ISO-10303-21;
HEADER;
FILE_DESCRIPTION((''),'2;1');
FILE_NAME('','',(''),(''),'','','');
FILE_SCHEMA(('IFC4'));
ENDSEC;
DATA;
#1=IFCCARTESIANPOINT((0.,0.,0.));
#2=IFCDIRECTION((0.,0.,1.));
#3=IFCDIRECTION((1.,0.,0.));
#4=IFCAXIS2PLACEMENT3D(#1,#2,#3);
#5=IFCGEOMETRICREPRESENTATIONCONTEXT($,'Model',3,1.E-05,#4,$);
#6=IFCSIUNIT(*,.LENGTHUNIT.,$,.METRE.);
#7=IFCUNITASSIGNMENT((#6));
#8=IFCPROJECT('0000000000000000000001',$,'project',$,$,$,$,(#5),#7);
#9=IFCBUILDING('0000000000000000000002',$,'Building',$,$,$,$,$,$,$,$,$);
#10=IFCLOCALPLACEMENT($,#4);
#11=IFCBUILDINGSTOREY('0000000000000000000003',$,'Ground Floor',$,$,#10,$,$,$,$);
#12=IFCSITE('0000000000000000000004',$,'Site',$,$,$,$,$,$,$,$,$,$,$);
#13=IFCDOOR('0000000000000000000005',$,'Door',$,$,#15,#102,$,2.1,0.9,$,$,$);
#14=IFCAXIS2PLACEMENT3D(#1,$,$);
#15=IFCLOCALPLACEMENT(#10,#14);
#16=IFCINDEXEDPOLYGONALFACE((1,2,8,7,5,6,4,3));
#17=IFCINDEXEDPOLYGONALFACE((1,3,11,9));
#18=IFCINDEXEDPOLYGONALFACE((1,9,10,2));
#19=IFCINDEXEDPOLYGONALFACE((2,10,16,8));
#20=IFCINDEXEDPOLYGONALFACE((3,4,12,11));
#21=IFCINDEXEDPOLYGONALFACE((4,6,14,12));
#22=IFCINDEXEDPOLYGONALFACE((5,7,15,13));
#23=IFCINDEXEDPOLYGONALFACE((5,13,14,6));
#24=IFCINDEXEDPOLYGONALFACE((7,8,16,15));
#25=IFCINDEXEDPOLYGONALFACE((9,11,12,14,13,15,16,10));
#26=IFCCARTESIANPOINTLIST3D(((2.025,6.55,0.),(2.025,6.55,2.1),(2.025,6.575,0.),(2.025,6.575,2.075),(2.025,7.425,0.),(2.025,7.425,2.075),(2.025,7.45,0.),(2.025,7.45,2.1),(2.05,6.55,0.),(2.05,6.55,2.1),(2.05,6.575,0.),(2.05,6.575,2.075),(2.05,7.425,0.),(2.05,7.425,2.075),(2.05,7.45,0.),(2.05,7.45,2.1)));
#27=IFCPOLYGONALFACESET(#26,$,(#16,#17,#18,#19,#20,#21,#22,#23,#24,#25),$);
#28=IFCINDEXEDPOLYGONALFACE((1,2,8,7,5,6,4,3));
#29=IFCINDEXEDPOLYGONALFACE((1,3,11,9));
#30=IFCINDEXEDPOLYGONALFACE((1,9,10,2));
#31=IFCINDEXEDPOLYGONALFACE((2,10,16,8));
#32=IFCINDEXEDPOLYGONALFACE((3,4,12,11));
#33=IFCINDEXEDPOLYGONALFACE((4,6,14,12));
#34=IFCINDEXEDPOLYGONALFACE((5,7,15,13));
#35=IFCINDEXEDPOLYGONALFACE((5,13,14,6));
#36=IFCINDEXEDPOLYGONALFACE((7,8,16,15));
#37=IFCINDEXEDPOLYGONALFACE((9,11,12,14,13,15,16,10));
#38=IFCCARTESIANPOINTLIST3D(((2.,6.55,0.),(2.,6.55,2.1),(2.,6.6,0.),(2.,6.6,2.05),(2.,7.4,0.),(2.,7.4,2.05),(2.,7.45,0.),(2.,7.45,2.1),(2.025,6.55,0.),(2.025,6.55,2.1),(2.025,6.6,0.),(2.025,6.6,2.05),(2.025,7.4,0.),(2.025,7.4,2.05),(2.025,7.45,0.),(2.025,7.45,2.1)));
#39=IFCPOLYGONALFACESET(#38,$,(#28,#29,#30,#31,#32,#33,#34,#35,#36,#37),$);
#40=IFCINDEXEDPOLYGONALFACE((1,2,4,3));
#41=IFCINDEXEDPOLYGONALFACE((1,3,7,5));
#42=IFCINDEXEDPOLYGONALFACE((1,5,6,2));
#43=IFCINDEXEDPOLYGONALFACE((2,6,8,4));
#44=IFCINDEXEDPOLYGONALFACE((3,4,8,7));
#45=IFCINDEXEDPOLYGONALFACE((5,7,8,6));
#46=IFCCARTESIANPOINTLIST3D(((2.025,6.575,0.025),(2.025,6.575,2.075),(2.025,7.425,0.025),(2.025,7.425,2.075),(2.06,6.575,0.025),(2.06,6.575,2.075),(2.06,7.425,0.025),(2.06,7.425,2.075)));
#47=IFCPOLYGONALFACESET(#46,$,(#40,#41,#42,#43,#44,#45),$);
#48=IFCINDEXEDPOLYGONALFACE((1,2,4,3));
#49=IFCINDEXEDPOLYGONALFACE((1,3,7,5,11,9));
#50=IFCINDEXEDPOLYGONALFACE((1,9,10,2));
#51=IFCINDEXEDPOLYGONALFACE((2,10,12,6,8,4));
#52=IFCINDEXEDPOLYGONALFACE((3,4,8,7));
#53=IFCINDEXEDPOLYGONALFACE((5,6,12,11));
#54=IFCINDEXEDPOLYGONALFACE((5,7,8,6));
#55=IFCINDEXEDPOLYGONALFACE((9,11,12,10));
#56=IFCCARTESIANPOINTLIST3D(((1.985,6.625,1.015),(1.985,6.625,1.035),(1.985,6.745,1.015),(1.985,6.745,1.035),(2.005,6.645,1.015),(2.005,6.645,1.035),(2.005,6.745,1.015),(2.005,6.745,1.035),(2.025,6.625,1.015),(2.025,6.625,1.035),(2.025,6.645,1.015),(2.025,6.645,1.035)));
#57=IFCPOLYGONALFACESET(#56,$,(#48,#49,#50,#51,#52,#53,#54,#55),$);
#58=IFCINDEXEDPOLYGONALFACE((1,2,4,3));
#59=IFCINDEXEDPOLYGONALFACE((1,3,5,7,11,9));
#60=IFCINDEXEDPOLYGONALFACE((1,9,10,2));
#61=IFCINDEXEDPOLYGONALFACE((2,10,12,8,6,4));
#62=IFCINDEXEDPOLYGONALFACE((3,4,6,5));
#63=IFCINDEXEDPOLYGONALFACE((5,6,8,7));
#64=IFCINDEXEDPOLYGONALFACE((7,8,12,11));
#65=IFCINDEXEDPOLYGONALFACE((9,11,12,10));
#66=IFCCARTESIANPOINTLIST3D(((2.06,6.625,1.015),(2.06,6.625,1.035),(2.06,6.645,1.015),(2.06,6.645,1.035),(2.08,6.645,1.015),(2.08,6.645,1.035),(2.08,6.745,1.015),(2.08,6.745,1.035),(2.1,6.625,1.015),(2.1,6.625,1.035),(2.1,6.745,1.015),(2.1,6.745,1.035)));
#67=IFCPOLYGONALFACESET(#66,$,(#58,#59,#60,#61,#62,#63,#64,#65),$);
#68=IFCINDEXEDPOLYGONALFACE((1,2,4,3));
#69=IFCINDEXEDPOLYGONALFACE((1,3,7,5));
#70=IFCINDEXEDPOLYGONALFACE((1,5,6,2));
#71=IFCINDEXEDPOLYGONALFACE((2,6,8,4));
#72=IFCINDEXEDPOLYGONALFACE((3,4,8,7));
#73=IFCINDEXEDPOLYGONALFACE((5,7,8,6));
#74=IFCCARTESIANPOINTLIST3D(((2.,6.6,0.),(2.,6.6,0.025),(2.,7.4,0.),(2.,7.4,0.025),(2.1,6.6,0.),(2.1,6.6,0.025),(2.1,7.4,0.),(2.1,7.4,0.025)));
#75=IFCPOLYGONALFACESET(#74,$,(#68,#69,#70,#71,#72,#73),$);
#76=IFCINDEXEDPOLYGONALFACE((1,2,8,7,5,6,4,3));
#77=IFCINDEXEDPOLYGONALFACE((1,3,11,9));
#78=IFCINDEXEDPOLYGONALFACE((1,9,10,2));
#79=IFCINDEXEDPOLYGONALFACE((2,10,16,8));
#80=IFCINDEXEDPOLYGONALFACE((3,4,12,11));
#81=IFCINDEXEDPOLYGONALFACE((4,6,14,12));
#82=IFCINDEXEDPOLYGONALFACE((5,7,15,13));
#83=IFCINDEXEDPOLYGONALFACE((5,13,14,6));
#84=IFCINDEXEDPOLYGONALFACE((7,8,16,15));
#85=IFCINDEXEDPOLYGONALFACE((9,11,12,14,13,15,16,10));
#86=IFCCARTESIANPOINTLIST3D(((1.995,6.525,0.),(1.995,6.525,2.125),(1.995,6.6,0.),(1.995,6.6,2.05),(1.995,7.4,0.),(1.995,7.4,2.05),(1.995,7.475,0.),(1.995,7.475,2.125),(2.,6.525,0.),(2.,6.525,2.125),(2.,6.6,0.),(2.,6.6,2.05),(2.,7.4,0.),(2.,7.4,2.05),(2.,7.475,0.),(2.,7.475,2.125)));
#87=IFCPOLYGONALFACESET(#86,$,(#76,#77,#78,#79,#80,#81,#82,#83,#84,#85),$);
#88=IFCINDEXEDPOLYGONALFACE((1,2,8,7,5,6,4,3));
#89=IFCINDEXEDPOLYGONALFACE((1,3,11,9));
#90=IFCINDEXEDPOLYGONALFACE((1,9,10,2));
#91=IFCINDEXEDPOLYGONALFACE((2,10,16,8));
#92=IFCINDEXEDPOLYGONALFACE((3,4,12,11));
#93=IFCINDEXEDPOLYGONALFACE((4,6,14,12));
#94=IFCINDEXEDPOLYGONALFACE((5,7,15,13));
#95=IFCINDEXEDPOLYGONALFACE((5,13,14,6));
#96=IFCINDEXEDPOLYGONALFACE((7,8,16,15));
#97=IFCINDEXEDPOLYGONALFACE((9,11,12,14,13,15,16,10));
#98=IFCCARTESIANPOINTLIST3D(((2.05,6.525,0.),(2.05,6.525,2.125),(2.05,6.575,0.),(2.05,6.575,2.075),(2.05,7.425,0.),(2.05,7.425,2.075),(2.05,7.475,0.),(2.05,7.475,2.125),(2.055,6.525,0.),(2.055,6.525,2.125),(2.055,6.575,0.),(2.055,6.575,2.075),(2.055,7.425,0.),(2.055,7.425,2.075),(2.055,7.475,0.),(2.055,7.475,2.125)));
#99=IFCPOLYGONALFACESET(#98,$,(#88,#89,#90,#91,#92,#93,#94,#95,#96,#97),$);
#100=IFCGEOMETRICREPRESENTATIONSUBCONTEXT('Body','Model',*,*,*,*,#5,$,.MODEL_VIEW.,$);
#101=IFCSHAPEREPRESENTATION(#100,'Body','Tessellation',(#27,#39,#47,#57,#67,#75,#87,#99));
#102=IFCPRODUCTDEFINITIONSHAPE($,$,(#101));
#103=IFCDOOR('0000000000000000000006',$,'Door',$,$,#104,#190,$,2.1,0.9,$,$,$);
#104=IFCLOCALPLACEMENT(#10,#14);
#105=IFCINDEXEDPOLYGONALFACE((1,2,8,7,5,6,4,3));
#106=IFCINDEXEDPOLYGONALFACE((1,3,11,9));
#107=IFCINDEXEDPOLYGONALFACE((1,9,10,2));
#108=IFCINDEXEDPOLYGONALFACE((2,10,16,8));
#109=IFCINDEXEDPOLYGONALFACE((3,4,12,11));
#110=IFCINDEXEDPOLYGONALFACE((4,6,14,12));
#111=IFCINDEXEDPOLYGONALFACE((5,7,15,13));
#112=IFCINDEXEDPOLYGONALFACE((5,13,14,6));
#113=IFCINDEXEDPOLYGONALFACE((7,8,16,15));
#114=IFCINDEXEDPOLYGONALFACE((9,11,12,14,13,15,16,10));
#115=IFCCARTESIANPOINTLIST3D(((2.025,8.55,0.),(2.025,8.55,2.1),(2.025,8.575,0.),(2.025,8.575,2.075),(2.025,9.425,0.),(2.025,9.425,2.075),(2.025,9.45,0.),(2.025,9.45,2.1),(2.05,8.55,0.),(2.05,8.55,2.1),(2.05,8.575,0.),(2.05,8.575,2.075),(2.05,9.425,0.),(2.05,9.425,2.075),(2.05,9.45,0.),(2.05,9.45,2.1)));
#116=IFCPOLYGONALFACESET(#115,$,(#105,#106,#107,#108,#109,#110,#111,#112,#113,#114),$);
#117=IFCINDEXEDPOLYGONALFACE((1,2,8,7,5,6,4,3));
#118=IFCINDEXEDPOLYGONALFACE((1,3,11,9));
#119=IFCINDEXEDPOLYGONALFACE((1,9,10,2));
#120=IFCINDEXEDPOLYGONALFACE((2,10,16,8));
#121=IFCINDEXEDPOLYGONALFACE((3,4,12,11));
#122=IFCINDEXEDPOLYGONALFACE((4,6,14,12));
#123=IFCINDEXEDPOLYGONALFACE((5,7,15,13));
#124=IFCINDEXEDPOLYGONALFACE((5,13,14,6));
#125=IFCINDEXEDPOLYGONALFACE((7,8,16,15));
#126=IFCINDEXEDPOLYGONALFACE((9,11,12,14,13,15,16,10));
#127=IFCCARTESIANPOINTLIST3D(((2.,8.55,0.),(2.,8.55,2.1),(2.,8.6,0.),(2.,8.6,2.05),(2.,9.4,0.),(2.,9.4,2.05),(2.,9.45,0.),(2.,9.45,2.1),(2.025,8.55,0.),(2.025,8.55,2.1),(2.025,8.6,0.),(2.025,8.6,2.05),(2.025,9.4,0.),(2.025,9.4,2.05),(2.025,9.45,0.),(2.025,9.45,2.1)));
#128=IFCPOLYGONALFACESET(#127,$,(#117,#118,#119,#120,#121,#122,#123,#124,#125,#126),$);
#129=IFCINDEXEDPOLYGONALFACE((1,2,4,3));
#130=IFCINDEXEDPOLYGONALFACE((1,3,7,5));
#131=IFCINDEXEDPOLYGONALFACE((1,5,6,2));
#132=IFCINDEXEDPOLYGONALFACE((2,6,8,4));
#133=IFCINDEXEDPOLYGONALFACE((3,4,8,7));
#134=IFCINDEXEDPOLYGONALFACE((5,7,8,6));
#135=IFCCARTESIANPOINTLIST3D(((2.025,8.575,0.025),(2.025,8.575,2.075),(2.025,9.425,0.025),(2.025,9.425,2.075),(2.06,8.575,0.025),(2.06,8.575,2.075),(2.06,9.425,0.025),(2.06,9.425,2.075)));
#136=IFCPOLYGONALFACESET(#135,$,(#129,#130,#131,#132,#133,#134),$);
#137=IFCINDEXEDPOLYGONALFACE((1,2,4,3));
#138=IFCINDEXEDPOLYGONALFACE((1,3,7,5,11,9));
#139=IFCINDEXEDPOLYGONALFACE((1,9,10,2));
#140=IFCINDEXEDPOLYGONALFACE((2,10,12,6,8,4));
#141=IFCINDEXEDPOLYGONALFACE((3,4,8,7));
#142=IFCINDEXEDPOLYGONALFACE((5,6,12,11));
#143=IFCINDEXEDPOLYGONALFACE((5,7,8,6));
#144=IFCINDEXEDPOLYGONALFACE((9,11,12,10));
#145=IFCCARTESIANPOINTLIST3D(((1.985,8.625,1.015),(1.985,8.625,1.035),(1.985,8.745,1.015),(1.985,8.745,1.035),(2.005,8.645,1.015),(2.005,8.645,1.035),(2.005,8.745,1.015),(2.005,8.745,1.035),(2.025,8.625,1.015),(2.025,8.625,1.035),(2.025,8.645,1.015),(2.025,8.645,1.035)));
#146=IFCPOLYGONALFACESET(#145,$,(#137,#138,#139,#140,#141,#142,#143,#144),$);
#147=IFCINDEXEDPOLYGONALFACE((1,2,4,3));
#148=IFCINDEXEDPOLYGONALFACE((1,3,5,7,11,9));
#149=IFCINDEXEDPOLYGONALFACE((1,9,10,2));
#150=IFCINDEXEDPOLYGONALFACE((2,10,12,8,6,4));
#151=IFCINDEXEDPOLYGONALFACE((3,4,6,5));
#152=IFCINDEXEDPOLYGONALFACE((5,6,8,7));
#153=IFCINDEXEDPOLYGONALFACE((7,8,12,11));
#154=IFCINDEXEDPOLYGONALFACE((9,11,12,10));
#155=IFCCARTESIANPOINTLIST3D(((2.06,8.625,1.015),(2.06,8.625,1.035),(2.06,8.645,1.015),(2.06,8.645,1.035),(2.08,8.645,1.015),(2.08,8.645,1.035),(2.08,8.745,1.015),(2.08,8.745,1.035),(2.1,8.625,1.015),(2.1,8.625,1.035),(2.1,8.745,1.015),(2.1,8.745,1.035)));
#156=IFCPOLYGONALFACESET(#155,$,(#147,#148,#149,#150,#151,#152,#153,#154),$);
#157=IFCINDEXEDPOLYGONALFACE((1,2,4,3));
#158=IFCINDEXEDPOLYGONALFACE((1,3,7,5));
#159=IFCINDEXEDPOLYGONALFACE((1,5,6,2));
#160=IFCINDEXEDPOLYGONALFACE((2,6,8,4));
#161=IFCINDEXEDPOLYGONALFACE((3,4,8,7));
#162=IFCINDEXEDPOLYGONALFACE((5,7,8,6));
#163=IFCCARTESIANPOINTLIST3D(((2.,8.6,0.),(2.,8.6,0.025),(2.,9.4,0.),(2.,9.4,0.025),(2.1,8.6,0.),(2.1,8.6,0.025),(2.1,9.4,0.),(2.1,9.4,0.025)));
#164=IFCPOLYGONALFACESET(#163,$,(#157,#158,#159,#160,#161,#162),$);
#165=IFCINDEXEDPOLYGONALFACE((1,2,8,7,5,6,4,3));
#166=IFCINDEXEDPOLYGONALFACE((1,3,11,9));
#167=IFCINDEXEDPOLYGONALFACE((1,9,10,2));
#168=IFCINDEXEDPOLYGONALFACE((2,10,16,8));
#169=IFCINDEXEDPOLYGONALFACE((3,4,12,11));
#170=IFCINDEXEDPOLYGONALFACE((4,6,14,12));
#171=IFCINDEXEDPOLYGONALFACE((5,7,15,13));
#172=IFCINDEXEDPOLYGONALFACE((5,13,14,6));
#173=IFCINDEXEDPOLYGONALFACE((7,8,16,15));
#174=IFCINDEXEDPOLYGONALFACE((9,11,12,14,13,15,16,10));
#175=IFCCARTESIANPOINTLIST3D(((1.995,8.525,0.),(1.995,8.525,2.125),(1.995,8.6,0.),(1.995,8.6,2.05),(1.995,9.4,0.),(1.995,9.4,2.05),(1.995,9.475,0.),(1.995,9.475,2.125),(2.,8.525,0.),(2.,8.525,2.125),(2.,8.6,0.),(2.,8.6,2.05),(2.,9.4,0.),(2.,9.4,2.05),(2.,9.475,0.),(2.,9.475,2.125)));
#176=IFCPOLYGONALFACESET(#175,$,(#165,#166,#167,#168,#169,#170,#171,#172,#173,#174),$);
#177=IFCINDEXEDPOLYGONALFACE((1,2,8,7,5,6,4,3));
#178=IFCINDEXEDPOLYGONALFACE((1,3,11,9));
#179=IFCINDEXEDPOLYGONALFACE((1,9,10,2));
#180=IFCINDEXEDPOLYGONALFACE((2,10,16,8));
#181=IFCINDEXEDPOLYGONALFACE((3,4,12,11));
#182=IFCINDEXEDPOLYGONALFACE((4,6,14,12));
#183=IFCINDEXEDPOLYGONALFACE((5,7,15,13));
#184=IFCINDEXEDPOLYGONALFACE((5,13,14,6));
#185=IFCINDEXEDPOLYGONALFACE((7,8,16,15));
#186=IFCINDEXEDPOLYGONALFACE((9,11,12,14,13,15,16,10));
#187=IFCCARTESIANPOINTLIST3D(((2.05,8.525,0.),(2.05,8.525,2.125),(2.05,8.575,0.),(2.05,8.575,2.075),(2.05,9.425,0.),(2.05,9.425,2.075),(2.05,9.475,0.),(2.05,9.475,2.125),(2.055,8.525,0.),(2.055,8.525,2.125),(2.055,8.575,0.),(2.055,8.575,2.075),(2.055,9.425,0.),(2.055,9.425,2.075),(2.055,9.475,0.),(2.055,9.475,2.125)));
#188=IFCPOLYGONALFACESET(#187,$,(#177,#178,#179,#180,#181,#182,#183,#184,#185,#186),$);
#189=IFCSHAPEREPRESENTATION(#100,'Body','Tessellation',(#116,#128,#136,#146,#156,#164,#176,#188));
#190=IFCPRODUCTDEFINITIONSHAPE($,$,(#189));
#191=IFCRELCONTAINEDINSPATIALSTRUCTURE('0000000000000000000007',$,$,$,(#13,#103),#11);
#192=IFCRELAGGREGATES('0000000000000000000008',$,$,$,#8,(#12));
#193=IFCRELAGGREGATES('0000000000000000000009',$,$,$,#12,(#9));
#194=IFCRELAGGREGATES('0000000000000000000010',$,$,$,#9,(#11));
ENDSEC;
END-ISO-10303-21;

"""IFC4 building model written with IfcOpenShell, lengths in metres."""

from ifc_helpers import new_model, si_unit, frame, origin_with_axes, place, context, subcontext, project, spatial, line, indexed_curve, outline, extrude, element, save


model = new_model("IFC4")

# Units and contexts
model_context = context("Model", 3, precision=1e-05, world=origin_with_axes())
body_context = subcontext(model_context, "Body", "Model", "MODEL_VIEW")
ifc_project = project(units=[si_unit("LENGTHUNIT", "METRE")], contexts=[model_context])

# Site, building, storey
site = spatial("IfcSite", under=ifc_project, Name="Site")
building = spatial("IfcBuilding", under=site, Name="Building")
storey_placement = place(None, origin_with_axes())
storey = spatial("IfcBuildingStorey", under=building, at=storey_placement, Name="Ground Floor")

# Doors
door_1_placement = place(storey_placement, frame((2.0, 7.45, 0.0), z_axis=(0.0, 0.0, 1.0), x_axis=(0.0, -1.0, 0.0)))
element("IfcDoor", 1, at=door_1_placement, inside=storey, Name="Door", OverallHeight=2.1, OverallWidth=0.9, context=body_context, shape_type="SweptSolid", body=[
    extrude(outline(indexed_curve([(0.0, 0.0), (0.0, 2.1), (0.9, 2.1), (0.9, 0.0), (0.875, 0.0), (0.875, 2.075), (0.025, 2.075), (0.025, 0.0)], segments=[line(1, 2, 3, 4, 5, 6, 7, 8, 1)])), frame((0.0, 0.025, 0.0), z_axis=(0.0, -1.0, 0.0), x_axis=(1.0, 0.0, 0.0)), (0.0, 0.0, -1.0), 0.025),
    extrude(outline(indexed_curve([(0.0, 0.0), (0.0, 2.1), (0.9, 2.1), (0.9, 0.0), (0.85, 0.0), (0.85, 2.05), (0.05, 2.05), (0.05, 0.0)], segments=[line(1, 2, 3, 4, 5, 6, 7, 8, 1)])), frame((0.0, 0.0, 0.0), z_axis=(0.0, -1.0, 0.0), x_axis=(1.0, 0.0, 0.0)), (0.0, 0.0, -1.0), 0.025),
    extrude(outline(indexed_curve([(0.0, 0.0), (0.85, 0.0), (0.85, 0.035), (0.0, 0.035)], segments=[line(1, 2, 3, 4, 1)])), frame((0.025, 0.025, 0.025), z_axis=(0.0, 0.0, 1.0), x_axis=(1.0, 0.0, 0.0)), (0.0, 0.0, 1.0), 2.05),
    extrude(outline(indexed_curve([(0.0, 0.0), (0.0, -0.04), (-0.12, -0.04), (-0.12, -0.02), (-0.02, -0.02), (-0.02, 0.0)], segments=[line(1, 2, 3, 4, 5, 6, 1)])), frame((0.825, 0.025, 1.015), z_axis=(0.0, 0.0, 1.0), x_axis=(1.0, 0.0, 0.0)), (0.0, 0.0, 1.0), 0.02),
    extrude(outline(indexed_curve([(0.0, 0.0), (0.0, 0.04), (-0.12, 0.04), (-0.12, 0.02), (-0.02, 0.02), (-0.02, 0.0)], segments=[line(1, 2, 3, 4, 5, 6, 1)])), frame((0.825, 0.06, 1.015), z_axis=(0.0, 0.0, 1.0), x_axis=(1.0, 0.0, 0.0)), (0.0, 0.0, 1.0), 0.02),
    extrude(outline(indexed_curve([(0.0, 0.0), (0.8, 0.0), (0.8, 0.1), (0.0, 0.1)], segments=[line(1, 2, 3, 4, 1)])), frame((0.05, 0.0, 0.0), z_axis=(0.0, 0.0, 1.0), x_axis=(1.0, 0.0, 0.0)), (0.0, 0.0, 1.0), 0.025),
    extrude(outline(indexed_curve([(0.0, 0.0), (0.0, 2.125), (0.95, 2.125), (0.95, 0.0), (0.875, 0.0), (0.875, 2.05), (0.075, 2.05), (0.075, 0.0)], segments=[line(1, 2, 3, 4, 5, 6, 7, 8, 1)])), frame((-0.025, -0.005, 0.0), z_axis=(0.0, -1.0, 0.0), x_axis=(1.0, 0.0, 0.0)), (0.0, 0.0, -1.0), 0.005),
    extrude(outline(indexed_curve([(0.0, 0.0), (0.0, 2.125), (0.95, 2.125), (0.95, 0.0), (0.9, 0.0), (0.9, 2.075), (0.05, 2.075), (0.05, 0.0)], segments=[line(1, 2, 3, 4, 5, 6, 7, 8, 1)])), frame((-0.025, 0.05, 0.0), z_axis=(0.0, -1.0, 0.0), x_axis=(1.0, 0.0, 0.0)), (0.0, 0.0, -1.0), 0.005),
])
door_2_placement = place(storey_placement, frame((2.0, 9.45, 0.0), z_axis=(0.0, 0.0, 1.0), x_axis=(0.0, -1.0, 0.0)))
element("IfcDoor", 2, at=door_2_placement, inside=storey, Name="Door", OverallHeight=2.1, OverallWidth=0.9, context=body_context, shape_type="SweptSolid", body=[
    extrude(outline(indexed_curve([(0.0, 0.0), (0.0, 2.1), (0.9, 2.1), (0.9, 0.0), (0.875, 0.0), (0.875, 2.075), (0.025, 2.075), (0.025, 0.0)], segments=[line(1, 2, 3, 4, 5, 6, 7, 8, 1)])), frame((0.0, 0.025, 0.0), z_axis=(0.0, -1.0, 0.0), x_axis=(1.0, 0.0, 0.0)), (0.0, 0.0, -1.0), 0.025),
    extrude(outline(indexed_curve([(0.0, 0.0), (0.0, 2.1), (0.9, 2.1), (0.9, 0.0), (0.85, 0.0), (0.85, 2.05), (0.05, 2.05), (0.05, 0.0)], segments=[line(1, 2, 3, 4, 5, 6, 7, 8, 1)])), frame((0.0, 0.0, 0.0), z_axis=(0.0, -1.0, 0.0), x_axis=(1.0, 0.0, 0.0)), (0.0, 0.0, -1.0), 0.025),
    extrude(outline(indexed_curve([(0.0, 0.0), (0.85, 0.0), (0.85, 0.035), (0.0, 0.035)], segments=[line(1, 2, 3, 4, 1)])), frame((0.025, 0.025, 0.025), z_axis=(0.0, 0.0, 1.0), x_axis=(1.0, 0.0, 0.0)), (0.0, 0.0, 1.0), 2.05),
    extrude(outline(indexed_curve([(0.0, 0.0), (0.0, -0.04), (-0.12, -0.04), (-0.12, -0.02), (-0.02, -0.02), (-0.02, 0.0)], segments=[line(1, 2, 3, 4, 5, 6, 1)])), frame((0.825, 0.025, 1.015), z_axis=(0.0, 0.0, 1.0), x_axis=(1.0, 0.0, 0.0)), (0.0, 0.0, 1.0), 0.02),
    extrude(outline(indexed_curve([(0.0, 0.0), (0.0, 0.04), (-0.12, 0.04), (-0.12, 0.02), (-0.02, 0.02), (-0.02, 0.0)], segments=[line(1, 2, 3, 4, 5, 6, 1)])), frame((0.825, 0.06, 1.015), z_axis=(0.0, 0.0, 1.0), x_axis=(1.0, 0.0, 0.0)), (0.0, 0.0, 1.0), 0.02),
    extrude(outline(indexed_curve([(0.0, 0.0), (0.8, 0.0), (0.8, 0.1), (0.0, 0.1)], segments=[line(1, 2, 3, 4, 1)])), frame((0.05, 0.0, 0.0), z_axis=(0.0, 0.0, 1.0), x_axis=(1.0, 0.0, 0.0)), (0.0, 0.0, 1.0), 0.025),
    extrude(outline(indexed_curve([(0.0, 0.0), (0.0, 2.125), (0.95, 2.125), (0.95, 0.0), (0.875, 0.0), (0.875, 2.05), (0.075, 2.05), (0.075, 0.0)], segments=[line(1, 2, 3, 4, 5, 6, 7, 8, 1)])), frame((-0.025, -0.005, 0.0), z_axis=(0.0, -1.0, 0.0), x_axis=(1.0, 0.0, 0.0)), (0.0, 0.0, -1.0), 0.005),
    extrude(outline(indexed_curve([(0.0, 0.0), (0.0, 2.125), (0.95, 2.125), (0.95, 0.0), (0.9, 0.0), (0.9, 2.075), (0.05, 2.075), (0.05, 0.0)], segments=[line(1, 2, 3, 4, 5, 6, 7, 8, 1)])), frame((-0.025, 0.05, 0.0), z_axis=(0.0, -1.0, 0.0), x_axis=(1.0, 0.0, 0.0)), (0.0, 0.0, -1.0), 0.005),
])

save(model, "model.ifc")
